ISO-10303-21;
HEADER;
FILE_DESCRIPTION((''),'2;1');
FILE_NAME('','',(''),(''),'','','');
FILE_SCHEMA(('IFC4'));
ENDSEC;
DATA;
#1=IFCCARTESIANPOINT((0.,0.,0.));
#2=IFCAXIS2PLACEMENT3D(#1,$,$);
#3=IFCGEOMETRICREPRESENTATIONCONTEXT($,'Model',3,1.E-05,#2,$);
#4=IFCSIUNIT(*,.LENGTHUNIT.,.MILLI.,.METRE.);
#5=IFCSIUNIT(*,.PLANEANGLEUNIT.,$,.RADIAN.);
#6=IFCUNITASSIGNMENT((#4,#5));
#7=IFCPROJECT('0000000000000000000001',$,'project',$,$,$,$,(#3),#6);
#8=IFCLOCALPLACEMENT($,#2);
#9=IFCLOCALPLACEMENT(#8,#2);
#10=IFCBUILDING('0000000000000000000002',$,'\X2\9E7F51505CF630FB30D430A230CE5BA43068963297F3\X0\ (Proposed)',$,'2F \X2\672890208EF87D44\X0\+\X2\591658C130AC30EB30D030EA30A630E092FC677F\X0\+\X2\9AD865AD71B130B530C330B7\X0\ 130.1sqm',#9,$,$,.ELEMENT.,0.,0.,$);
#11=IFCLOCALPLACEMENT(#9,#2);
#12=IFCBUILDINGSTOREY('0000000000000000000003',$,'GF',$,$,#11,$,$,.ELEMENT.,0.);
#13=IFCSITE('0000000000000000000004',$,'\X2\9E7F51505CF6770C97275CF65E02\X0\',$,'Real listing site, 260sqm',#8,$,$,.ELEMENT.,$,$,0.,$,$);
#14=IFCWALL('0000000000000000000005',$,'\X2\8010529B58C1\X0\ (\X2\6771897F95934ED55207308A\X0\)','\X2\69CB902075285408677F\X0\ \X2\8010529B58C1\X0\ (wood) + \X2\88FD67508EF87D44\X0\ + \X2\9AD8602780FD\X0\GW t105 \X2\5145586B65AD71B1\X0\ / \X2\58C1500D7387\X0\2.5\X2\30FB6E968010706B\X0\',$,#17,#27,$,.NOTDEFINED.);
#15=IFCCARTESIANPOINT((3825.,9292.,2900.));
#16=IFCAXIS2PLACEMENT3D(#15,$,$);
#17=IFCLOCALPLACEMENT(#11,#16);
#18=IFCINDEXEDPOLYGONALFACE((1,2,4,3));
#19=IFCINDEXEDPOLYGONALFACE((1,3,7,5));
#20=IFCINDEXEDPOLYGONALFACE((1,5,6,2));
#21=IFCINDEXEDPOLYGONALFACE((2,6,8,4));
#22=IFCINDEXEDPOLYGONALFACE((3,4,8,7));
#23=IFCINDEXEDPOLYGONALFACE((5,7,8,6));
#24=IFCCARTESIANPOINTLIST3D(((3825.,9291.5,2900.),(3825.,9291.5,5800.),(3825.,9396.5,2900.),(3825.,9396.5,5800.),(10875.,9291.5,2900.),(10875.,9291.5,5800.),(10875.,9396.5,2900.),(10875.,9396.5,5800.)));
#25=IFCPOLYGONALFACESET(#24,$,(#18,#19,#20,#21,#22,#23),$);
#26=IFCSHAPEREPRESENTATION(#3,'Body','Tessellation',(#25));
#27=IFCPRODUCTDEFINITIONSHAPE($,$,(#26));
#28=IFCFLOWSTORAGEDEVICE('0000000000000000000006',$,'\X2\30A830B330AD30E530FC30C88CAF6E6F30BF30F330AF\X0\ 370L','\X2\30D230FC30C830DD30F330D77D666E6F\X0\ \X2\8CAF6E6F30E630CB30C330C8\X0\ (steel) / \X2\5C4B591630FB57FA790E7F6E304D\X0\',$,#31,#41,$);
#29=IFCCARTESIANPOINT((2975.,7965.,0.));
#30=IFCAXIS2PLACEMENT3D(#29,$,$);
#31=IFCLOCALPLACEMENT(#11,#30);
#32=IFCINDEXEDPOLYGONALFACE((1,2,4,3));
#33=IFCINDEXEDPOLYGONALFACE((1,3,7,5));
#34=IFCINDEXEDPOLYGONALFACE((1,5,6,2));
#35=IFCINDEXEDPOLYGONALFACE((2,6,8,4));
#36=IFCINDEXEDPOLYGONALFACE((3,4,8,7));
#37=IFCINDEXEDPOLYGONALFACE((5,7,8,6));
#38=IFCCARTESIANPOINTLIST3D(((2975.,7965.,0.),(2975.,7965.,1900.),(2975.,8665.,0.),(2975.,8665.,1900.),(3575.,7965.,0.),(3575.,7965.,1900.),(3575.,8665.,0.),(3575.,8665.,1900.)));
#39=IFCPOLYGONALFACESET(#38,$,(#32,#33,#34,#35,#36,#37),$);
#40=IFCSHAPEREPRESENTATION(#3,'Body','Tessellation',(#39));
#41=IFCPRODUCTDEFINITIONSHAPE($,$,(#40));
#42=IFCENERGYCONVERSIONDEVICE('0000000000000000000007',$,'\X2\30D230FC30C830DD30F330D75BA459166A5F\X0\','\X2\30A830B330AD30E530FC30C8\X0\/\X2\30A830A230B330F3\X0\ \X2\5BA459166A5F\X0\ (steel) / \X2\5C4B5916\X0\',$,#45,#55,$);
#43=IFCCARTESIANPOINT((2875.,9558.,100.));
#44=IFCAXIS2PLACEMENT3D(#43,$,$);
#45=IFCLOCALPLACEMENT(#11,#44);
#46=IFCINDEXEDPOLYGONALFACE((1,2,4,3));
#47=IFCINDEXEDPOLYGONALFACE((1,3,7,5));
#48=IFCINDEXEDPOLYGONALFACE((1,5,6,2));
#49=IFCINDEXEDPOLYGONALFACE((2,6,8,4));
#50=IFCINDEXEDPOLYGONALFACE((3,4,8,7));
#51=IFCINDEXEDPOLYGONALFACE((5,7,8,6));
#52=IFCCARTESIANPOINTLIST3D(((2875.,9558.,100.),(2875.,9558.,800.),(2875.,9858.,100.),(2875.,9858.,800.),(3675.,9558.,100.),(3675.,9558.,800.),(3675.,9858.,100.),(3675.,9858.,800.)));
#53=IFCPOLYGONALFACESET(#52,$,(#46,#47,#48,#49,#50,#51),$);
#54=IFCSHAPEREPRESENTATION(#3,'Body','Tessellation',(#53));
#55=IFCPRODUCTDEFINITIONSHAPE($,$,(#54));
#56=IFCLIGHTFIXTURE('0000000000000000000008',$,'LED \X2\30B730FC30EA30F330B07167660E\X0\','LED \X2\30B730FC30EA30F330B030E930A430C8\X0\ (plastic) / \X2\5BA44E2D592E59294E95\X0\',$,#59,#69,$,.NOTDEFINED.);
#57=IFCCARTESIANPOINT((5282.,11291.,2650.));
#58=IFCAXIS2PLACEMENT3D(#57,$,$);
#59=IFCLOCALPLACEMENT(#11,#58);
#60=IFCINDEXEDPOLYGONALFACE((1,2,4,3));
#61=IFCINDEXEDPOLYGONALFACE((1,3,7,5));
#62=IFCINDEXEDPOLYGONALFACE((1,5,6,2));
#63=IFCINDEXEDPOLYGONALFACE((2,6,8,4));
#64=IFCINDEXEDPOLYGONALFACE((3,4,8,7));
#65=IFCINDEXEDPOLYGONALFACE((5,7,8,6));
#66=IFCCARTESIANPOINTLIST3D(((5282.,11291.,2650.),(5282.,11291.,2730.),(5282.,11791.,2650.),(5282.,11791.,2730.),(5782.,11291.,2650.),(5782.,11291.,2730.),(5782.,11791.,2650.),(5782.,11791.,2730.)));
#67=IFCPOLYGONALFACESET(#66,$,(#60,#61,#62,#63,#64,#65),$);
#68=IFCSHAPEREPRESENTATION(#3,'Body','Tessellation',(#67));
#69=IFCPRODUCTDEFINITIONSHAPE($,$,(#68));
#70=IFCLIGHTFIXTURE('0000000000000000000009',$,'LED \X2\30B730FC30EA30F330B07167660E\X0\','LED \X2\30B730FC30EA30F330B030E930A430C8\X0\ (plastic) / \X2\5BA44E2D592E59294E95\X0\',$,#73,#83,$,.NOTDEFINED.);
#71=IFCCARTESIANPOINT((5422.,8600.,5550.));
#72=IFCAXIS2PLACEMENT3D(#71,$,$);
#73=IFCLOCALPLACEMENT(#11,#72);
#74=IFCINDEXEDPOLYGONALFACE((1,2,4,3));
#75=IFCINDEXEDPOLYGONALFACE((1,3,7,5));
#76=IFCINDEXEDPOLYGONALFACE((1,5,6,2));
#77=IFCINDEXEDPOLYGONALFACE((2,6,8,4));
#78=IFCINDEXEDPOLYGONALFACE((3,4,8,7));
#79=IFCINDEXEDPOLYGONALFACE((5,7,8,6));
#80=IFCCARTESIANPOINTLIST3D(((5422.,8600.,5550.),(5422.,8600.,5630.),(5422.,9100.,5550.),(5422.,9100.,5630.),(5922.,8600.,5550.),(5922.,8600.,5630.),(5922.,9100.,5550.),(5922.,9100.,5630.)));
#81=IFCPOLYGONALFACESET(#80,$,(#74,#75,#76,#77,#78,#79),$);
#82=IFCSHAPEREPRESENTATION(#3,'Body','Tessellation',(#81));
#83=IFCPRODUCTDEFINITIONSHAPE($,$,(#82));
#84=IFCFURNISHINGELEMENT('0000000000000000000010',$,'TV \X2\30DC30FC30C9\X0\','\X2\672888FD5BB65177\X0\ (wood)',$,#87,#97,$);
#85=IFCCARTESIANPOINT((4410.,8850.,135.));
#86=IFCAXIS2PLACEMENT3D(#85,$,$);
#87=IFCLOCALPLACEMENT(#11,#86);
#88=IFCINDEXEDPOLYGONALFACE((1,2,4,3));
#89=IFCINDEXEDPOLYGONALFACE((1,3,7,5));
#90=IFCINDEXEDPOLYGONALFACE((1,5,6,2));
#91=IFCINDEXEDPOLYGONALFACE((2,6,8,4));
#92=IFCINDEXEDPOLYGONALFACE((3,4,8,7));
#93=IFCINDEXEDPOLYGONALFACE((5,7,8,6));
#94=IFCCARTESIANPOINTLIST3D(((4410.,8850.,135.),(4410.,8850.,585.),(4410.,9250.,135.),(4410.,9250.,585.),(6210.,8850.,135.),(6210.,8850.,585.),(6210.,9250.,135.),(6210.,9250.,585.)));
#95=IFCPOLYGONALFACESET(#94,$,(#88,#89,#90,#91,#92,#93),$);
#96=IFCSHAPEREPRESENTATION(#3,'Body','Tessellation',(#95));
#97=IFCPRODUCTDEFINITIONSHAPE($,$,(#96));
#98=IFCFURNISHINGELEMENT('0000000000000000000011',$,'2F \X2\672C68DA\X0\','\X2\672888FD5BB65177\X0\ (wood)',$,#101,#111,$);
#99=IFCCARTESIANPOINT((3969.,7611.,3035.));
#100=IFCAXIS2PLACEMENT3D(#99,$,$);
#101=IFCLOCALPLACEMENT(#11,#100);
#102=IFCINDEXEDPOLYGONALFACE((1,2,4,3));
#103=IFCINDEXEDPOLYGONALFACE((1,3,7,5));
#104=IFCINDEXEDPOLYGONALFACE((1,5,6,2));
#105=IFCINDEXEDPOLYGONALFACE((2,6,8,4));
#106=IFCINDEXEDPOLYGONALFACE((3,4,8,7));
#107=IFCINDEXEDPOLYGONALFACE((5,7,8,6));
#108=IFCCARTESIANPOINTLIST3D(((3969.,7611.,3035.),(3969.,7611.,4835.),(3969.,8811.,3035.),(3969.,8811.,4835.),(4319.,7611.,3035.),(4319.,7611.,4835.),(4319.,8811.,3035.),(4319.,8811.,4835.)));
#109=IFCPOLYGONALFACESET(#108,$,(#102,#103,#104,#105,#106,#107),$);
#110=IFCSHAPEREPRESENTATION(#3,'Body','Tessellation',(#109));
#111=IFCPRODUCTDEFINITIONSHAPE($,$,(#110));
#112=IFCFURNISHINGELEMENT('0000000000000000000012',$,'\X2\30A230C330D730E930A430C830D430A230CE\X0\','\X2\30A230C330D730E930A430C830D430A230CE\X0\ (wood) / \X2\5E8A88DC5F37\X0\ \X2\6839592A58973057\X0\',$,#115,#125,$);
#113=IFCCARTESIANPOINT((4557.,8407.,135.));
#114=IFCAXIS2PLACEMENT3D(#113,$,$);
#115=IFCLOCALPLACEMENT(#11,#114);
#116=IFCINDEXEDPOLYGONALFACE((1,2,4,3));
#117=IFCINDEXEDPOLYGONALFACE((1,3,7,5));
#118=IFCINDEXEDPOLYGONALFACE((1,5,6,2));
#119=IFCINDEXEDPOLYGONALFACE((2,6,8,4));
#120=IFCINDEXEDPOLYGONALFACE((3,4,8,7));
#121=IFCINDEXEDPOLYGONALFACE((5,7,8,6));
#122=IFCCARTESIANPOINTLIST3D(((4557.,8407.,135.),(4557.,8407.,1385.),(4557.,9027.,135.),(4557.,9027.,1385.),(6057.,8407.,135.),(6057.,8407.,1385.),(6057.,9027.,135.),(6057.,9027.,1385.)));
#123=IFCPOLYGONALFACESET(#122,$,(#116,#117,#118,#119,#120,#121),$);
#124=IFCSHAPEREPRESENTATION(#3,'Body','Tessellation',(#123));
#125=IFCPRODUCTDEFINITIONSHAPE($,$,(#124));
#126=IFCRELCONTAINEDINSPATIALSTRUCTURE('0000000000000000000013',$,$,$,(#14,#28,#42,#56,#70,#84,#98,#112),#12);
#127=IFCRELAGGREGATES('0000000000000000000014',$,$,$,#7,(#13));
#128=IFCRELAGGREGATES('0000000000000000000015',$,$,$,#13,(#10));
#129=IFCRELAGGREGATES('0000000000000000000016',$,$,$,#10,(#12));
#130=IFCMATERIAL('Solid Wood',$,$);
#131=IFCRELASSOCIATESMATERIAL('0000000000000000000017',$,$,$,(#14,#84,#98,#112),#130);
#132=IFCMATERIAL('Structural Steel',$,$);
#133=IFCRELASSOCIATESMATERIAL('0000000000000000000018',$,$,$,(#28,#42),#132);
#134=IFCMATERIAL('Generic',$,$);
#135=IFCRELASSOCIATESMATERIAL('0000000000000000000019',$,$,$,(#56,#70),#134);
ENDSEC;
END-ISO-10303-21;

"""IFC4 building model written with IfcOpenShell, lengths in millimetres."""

from ifc_helpers import new_model, si_unit, frame, frame_2d, origin, place, context, project, spatial, rectangle, extrude, material, element, save


model = new_model("IFC4")

# Units and contexts
model_context = context("Model", 3, precision=1e-05, world=origin())
ifc_project = project(units=[si_unit("LENGTHUNIT", "METRE", prefix="MILLI"), si_unit("PLANEANGLEUNIT", "RADIAN")], contexts=[model_context])

# Site, building, storey
site_placement = place(None, origin())
site = spatial("IfcSite", under=ifc_project, at=site_placement, Name="鹿児島県霧島市", ObjectType="Real listing site, 260sqm", CompositionType="ELEMENT", RefElevation=0.0)
building_placement = place(site_placement, origin())
building = spatial("IfcBuilding", under=site, at=building_placement, Name="鹿児島・ピアノ室と防音 (Proposed)", ObjectType="2F 木造軸組+外壁ガルバリウム鋼板+高断熱サッシ 130.1sqm", CompositionType="ELEMENT", ElevationOfRefHeight=0.0, ElevationOfTerrain=0.0)
storey_placement = place(building_placement, origin())
storey = spatial("IfcBuildingStorey", under=building, at=storey_placement, Name="GF", CompositionType="ELEMENT", Elevation=0.0)

# Shared definitions
ifc_material_1 = material(Name="Solid Wood")

# Wall
wall_1_placement = place(storey_placement, frame((3825.0, 9292.0, 2900.0)))
element("IfcWall", 1, at=wall_1_placement, inside=storey, material=ifc_material_1, Name="耐力壁 (東西間仕切り)", Description="構造用合板 耐力壁 (wood) + 製材軸組 + 高性能GW t105 充填断熱 / 壁倍率2.5・準耐火", PredefinedType="NOTDEFINED", context=model_context, shape_type="SweptSolid", body=[
    extrude(rectangle(XDim=7050.0, YDim=105.0, at=frame_2d((3525.0, 52.0))), frame((3825.0, 9292.0, 2900.0)), (0.0, 0.0, 1.0), 2900.0),
])

# Flow storage device
ifc_material_2 = material(Name="Structural Steel")
flow_storage_device_placement = place(storey_placement, frame((2975.0, 7965.0, 0.0)))
element("IfcFlowStorageDevice", 2, at=flow_storage_device_placement, inside=storey, material=ifc_material_2, Name="エコキュート貯湯タンク 370L", Description="ヒートポンプ給湯 貯湯ユニット (steel) / 屋外・基礎置き", context=model_context, shape_type="SweptSolid", body=[
    extrude(rectangle(XDim=600.0, YDim=700.0, at=frame_2d((300.0, 350.0))), frame((2975.0, 7965.0, 0.0)), (0.0, 0.0, 1.0), 1900.0),
])

# Energy conversion device
energy_conversion_device_placement = place(storey_placement, frame((2875.0, 9558.0, 100.0)))
element("IfcEnergyConversionDevice", 3, at=energy_conversion_device_placement, inside=storey, material=ifc_material_2, Name="ヒートポンプ室外機", Description="エコキュート/エアコン 室外機 (steel) / 屋外", context=model_context, shape_type="SweptSolid", body=[
    extrude(rectangle(XDim=800.0, YDim=300.0, at=frame_2d((400.0, 150.0))), frame((2875.0, 9558.0, 100.0)), (0.0, 0.0, 1.0), 700.0),
])

# Light fixtures
ifc_material_3 = material(Name="Generic")
light_fixture_1_placement = place(storey_placement, frame((5282.0, 11291.0, 2650.0)))
element("IfcLightFixture", 4, at=light_fixture_1_placement, inside=storey, material=ifc_material_3, Name="LED シーリング照明", Description="LED シーリングライト (plastic) / 室中央天井", PredefinedType="NOTDEFINED", context=model_context, shape_type="SweptSolid", body=[
    extrude(rectangle(XDim=500.0, YDim=500.0, at=frame_2d((250.0, 250.0))), frame((5282.0, 11291.0, 2650.0)), (0.0, 0.0, 1.0), 80.0),
])
light_fixture_2_placement = place(storey_placement, frame((5422.0, 8600.0, 5550.0)))
element("IfcLightFixture", 5, at=light_fixture_2_placement, inside=storey, material=ifc_material_3, Name="LED シーリング照明", Description="LED シーリングライト (plastic) / 室中央天井", PredefinedType="NOTDEFINED", context=model_context, shape_type="SweptSolid", body=[
    extrude(rectangle(XDim=500.0, YDim=500.0, at=frame_2d((250.0, 250.0))), frame((5422.0, 8600.0, 5550.0)), (0.0, 0.0, 1.0), 80.0),
])

# Furnishing elements
furnishing_1_placement = place(storey_placement, frame((4410.0, 8850.0, 135.0)))
element("IfcFurnishingElement", 6, at=furnishing_1_placement, inside=storey, material=ifc_material_1, Name="TV ボード", Description="木製家具 (wood)", context=model_context, shape_type="SweptSolid", body=[
    extrude(rectangle(XDim=1800.0, YDim=400.0, at=frame_2d((900.0, 200.0))), frame((4410.0, 8850.0, 135.0)), (0.0, 0.0, 1.0), 450.0),
])
furnishing_2_placement = place(storey_placement, frame((3969.0, 7611.0, 3035.0)))
element("IfcFurnishingElement", 7, at=furnishing_2_placement, inside=storey, material=ifc_material_1, Name="2F 本棚", Description="木製家具 (wood)", context=model_context, shape_type="SweptSolid", body=[
    extrude(rectangle(XDim=350.0, YDim=1200.0, at=frame_2d((175.0, 600.0))), frame((3969.0, 7611.0, 3035.0)), (0.0, 0.0, 1.0), 1800.0),
])
furnishing_3_placement = place(storey_placement, frame((4557.0, 8407.0, 135.0)))
element("IfcFurnishingElement", 8, at=furnishing_3_placement, inside=storey, material=ifc_material_1, Name="アップライトピアノ", Description="アップライトピアノ (wood) / 床補強 根太増し", context=model_context, shape_type="SweptSolid", body=[
    extrude(rectangle(XDim=1500.0, YDim=620.0, at=frame_2d((750.0, 310.0))), frame((4557.0, 8407.0, 135.0)), (0.0, 0.0, 1.0), 1250.0),
])

save(model, "model.ifc")
